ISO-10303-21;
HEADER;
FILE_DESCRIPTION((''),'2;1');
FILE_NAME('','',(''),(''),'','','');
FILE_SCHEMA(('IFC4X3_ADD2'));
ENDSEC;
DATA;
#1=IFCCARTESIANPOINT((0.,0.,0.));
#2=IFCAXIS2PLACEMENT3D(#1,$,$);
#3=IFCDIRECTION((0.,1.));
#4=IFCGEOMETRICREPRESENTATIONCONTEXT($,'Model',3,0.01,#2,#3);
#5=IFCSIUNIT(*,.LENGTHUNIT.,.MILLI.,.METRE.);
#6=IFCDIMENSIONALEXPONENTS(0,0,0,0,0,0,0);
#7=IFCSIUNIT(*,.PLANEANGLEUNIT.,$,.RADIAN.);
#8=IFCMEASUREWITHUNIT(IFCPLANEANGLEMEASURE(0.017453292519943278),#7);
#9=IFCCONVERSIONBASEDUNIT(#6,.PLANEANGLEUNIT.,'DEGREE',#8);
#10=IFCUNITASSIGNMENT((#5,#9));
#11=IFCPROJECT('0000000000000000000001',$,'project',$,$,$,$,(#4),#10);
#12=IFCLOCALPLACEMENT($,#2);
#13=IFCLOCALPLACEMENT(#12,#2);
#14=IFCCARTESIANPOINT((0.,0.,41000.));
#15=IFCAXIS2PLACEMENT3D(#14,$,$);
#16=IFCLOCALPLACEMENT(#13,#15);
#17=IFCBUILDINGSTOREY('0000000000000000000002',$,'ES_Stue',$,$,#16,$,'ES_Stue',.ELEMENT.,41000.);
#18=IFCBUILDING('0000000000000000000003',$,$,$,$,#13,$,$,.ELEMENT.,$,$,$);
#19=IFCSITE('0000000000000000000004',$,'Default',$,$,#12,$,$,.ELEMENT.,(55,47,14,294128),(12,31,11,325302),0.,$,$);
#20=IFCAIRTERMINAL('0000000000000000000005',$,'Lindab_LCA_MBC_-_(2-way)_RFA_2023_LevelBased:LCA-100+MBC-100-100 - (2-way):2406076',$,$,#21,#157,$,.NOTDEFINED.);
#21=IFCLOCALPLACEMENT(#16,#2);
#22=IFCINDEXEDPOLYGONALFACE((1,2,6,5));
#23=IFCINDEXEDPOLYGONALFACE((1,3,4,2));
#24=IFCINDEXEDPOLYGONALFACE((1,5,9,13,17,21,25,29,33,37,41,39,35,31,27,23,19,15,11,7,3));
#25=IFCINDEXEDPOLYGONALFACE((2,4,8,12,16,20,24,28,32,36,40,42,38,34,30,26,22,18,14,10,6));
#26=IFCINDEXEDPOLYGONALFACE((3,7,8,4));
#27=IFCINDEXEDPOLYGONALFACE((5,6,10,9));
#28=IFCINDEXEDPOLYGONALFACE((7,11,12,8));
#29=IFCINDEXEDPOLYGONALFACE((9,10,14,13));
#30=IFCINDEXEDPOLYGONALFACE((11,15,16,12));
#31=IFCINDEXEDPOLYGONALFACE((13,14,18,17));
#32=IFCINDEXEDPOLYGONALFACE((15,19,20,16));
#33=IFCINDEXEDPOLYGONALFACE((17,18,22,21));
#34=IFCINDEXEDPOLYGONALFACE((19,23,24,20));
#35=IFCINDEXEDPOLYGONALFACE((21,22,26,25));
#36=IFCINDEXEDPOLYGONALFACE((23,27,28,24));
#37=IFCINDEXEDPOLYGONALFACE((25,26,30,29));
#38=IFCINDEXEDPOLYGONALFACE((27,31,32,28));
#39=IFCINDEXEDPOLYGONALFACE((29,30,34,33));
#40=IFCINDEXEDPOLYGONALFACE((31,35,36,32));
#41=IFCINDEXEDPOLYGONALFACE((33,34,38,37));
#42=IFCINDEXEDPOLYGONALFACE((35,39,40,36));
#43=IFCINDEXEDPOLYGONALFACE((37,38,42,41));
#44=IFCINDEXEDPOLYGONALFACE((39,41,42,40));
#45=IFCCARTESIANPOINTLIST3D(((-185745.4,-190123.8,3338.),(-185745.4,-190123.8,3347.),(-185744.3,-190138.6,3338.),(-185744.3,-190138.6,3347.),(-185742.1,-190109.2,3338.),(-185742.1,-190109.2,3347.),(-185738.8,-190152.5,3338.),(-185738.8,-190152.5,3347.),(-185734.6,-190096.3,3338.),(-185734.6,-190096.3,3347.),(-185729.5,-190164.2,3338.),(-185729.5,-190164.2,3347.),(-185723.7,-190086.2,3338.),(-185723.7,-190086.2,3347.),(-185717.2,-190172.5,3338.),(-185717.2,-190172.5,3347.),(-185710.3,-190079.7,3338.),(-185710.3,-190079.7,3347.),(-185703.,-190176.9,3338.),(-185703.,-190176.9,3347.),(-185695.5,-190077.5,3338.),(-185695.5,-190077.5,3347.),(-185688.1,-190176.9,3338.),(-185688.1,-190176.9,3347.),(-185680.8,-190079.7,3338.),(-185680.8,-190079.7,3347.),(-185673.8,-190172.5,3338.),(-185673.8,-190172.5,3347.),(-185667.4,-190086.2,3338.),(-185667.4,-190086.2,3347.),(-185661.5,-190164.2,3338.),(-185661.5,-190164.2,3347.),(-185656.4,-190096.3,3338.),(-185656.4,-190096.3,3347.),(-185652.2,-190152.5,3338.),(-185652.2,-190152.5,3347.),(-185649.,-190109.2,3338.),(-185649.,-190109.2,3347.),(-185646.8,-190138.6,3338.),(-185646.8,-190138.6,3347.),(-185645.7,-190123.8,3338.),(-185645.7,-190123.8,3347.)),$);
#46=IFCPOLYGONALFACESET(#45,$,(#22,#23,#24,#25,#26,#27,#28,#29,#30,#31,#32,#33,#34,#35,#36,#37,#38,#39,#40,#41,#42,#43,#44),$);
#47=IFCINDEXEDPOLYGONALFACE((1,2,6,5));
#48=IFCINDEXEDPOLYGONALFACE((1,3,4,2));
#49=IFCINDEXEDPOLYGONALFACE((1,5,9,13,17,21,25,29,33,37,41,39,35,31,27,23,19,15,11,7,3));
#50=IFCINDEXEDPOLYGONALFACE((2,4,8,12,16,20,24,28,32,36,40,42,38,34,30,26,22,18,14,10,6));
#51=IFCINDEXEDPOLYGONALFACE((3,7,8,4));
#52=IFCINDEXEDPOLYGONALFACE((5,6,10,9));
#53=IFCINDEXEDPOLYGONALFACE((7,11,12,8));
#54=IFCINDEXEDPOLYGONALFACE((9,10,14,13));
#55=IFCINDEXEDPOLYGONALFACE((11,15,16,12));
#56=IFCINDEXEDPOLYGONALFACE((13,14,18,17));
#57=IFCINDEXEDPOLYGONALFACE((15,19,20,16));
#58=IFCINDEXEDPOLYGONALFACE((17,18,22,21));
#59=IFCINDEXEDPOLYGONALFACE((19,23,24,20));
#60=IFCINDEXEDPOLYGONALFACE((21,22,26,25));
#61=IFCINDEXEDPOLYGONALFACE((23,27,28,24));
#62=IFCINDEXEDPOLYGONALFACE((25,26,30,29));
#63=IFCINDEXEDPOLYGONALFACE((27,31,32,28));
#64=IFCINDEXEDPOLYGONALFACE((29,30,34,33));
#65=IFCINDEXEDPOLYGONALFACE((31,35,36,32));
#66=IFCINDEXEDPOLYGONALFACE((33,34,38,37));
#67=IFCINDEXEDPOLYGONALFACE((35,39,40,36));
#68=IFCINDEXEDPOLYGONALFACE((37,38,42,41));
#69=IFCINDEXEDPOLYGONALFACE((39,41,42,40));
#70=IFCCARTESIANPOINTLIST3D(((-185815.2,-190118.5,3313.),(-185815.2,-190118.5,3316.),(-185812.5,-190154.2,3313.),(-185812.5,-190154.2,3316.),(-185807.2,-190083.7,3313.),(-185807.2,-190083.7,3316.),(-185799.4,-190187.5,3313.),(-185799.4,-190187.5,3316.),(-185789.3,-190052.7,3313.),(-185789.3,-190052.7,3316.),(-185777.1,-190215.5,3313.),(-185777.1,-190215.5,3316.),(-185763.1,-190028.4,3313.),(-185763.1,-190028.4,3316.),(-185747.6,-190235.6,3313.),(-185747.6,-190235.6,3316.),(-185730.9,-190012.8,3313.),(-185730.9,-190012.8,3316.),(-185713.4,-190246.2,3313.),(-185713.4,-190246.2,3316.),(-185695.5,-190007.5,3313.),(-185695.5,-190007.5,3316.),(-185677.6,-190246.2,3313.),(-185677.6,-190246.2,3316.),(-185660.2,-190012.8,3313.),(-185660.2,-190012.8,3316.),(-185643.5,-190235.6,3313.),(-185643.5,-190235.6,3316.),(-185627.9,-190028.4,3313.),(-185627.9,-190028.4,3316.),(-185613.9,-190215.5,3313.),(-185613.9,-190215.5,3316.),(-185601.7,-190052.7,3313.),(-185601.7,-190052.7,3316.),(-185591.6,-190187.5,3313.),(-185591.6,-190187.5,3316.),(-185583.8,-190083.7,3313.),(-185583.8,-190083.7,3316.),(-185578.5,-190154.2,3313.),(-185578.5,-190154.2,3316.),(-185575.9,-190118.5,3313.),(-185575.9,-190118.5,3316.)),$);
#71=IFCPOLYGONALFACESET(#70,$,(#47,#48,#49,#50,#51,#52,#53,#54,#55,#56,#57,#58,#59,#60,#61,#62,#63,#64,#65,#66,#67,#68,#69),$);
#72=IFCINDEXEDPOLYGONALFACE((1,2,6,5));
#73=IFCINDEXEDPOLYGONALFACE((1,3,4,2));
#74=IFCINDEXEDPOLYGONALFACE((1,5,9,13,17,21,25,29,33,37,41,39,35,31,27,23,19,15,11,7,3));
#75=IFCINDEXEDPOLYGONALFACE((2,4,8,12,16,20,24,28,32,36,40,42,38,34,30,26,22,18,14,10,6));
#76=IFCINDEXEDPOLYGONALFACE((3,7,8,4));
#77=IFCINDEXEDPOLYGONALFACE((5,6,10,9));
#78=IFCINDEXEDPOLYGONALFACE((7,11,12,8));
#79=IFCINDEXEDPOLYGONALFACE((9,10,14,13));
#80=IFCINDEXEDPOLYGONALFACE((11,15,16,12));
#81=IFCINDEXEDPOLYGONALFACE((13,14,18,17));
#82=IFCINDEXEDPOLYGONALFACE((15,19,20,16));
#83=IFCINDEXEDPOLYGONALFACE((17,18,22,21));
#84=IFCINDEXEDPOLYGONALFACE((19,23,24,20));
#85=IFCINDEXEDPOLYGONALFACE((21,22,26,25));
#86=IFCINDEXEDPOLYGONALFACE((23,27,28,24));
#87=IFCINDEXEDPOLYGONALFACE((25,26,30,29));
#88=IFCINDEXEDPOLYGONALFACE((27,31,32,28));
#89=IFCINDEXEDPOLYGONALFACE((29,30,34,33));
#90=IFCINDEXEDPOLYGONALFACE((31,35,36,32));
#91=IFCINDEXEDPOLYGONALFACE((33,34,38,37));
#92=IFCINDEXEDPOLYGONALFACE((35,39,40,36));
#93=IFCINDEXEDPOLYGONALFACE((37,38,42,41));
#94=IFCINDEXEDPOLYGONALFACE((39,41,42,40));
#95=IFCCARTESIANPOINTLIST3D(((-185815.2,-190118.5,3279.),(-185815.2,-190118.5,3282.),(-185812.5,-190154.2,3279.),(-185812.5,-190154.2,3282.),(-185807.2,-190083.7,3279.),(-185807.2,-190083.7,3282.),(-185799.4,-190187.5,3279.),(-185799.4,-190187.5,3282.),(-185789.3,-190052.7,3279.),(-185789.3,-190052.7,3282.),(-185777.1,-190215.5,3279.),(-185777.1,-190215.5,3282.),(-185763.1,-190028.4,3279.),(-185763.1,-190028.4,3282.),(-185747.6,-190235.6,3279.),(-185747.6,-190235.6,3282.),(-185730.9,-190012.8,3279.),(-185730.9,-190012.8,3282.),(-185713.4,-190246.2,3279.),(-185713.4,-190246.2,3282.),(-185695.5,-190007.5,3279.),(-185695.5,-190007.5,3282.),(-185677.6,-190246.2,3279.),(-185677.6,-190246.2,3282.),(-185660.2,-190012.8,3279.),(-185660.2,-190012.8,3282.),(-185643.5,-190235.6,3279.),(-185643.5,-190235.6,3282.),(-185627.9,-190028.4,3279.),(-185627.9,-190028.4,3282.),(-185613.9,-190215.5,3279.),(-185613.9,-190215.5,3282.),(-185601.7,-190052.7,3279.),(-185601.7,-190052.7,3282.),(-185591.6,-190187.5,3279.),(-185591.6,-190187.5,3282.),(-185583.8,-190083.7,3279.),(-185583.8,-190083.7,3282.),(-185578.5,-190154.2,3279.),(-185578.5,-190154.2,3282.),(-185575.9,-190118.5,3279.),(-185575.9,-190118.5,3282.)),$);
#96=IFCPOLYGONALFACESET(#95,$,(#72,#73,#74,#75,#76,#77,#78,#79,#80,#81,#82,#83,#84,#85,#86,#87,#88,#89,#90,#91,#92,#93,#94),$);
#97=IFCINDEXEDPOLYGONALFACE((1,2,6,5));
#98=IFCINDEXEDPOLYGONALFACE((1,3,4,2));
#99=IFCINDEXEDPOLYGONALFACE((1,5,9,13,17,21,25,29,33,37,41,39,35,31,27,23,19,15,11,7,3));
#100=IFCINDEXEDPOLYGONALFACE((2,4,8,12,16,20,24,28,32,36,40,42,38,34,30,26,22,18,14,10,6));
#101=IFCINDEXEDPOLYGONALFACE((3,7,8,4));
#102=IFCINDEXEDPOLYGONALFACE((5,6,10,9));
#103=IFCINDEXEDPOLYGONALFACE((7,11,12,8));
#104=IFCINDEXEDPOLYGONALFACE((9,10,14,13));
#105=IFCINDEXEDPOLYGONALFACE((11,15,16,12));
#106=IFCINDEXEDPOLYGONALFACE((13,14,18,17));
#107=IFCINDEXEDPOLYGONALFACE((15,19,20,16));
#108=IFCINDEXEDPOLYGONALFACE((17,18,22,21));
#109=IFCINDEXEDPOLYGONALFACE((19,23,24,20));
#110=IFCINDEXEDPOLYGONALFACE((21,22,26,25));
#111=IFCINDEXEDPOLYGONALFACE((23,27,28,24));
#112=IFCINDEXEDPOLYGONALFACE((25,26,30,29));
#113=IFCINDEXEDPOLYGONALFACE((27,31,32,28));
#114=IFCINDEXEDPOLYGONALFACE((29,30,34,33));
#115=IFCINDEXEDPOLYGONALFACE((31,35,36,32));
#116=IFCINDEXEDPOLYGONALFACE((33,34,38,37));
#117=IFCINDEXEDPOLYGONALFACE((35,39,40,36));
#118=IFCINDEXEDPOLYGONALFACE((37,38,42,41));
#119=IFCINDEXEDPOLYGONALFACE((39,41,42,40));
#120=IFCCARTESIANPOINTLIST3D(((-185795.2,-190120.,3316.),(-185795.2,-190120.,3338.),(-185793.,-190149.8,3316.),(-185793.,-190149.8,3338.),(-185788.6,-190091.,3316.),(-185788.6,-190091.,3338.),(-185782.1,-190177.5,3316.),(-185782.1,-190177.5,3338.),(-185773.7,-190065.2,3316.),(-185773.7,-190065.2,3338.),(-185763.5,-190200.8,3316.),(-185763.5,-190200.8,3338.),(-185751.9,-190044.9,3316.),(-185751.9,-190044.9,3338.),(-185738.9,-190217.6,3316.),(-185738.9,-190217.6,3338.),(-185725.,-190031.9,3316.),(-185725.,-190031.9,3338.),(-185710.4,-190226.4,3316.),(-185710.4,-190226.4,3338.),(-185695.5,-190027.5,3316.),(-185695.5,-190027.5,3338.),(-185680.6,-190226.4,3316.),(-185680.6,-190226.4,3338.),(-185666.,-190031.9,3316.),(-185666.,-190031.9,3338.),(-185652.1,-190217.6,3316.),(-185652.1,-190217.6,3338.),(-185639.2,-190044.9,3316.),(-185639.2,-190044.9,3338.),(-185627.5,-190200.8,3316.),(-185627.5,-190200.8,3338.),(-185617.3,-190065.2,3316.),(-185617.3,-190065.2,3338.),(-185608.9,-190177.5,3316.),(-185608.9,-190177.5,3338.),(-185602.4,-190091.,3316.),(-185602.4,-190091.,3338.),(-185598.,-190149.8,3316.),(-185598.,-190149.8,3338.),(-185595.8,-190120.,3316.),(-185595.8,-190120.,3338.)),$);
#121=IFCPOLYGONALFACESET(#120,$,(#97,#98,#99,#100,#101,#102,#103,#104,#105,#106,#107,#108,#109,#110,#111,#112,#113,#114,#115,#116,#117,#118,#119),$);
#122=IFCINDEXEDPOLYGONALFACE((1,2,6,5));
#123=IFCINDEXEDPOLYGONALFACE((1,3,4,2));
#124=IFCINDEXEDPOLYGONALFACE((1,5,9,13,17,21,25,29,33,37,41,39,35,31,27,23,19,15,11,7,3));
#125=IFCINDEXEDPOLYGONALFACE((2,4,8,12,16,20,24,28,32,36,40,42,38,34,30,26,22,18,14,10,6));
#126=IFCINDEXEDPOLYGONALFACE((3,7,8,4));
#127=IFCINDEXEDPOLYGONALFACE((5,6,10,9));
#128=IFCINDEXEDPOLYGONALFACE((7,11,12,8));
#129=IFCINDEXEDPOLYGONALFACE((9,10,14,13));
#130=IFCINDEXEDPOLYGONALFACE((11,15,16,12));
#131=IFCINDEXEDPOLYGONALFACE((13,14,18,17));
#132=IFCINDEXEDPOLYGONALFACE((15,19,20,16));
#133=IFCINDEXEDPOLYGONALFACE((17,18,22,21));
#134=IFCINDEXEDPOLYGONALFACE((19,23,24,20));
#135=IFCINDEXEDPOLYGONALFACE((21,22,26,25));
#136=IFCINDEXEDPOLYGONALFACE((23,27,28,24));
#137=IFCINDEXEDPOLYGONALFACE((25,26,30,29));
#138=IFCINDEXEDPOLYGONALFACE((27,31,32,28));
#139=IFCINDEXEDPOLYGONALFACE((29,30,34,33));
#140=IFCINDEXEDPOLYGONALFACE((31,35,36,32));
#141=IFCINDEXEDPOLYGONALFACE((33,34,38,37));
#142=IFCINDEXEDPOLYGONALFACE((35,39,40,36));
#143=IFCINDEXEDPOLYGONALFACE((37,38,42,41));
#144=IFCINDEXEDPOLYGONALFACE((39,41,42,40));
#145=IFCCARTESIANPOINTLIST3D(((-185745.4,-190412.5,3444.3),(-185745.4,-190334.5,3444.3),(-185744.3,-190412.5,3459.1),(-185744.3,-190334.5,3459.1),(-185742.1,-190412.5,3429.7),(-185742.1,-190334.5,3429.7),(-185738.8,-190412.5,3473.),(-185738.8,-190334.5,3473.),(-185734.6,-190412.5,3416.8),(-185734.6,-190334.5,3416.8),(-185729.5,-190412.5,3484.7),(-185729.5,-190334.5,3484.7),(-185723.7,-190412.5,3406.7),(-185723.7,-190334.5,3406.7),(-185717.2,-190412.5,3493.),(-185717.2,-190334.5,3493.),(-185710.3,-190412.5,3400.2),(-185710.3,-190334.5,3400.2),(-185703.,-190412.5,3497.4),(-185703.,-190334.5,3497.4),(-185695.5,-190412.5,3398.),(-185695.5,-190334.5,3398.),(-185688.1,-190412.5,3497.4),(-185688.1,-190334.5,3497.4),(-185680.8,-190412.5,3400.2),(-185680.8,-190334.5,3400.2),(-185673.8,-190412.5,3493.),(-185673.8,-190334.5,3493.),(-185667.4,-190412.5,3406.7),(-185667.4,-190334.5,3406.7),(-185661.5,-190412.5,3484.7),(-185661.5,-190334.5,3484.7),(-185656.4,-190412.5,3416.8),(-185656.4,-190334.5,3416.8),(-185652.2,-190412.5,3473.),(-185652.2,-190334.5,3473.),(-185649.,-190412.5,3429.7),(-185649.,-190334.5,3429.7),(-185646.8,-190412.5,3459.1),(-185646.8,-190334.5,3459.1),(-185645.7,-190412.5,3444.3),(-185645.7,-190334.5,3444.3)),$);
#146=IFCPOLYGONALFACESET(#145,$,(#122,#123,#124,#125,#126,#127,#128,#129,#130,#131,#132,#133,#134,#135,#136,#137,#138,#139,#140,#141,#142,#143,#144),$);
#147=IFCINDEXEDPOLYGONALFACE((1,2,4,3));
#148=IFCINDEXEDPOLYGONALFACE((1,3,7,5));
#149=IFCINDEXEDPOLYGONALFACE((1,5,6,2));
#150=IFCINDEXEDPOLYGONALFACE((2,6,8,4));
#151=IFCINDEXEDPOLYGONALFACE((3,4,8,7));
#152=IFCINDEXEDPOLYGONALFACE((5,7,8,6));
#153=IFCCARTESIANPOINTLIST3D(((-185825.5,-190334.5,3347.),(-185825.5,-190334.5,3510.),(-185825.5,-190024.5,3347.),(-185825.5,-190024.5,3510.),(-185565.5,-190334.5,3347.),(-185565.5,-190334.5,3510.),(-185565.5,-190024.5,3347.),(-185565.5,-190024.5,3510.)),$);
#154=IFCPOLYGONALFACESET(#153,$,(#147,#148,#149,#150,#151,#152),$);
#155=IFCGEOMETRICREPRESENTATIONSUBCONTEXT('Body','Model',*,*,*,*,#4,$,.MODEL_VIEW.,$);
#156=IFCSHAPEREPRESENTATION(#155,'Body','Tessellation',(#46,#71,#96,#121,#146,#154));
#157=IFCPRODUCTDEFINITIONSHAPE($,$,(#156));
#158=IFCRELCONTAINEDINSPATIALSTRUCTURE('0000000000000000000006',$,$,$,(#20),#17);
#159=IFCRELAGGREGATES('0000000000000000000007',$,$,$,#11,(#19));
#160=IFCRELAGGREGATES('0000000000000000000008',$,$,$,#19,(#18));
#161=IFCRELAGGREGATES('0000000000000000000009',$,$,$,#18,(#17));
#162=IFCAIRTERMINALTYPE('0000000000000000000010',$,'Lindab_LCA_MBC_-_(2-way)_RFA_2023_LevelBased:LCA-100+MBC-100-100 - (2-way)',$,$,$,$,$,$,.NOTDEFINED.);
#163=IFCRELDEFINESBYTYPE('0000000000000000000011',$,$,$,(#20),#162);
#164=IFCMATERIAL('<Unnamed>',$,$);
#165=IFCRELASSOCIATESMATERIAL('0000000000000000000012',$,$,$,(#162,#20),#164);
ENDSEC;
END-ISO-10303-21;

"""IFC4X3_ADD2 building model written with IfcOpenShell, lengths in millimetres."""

from ifc_helpers import new_model, entity, si_unit, converted_unit, direction, frame, frame_2d, origin, origin_2d_with_axis, place, context, subcontext, project, spatial, rectangle, circle, extrude, source, transform, mapped, material, type_object, type_shapes, element, save


model = new_model("IFC4X3_ADD2")

# Units and contexts
model_context = context("Model", 3, precision=0.01, world=origin(), true_north=direction((0.0, 1.0)))
body_context = subcontext(model_context, "Body", "Model", "MODEL_VIEW")
ifc_project = project(units=[si_unit("LENGTHUNIT", "METRE", prefix="MILLI"), converted_unit("PLANEANGLEUNIT", "DEGREE", entity("IfcPlaneAngleMeasure", 0.017453292519943278), si_unit("PLANEANGLEUNIT", "RADIAN"), dimensions=[0, 0, 0, 0, 0, 0, 0])], contexts=[model_context])

# Site, building, storey
site_placement = place(None, origin())
site = spatial("IfcSite", under=ifc_project, at=site_placement, Name="Default", CompositionType="ELEMENT", RefLatitude=(55, 47, 14, 294128), RefLongitude=(12, 31, 11, 325302), RefElevation=0.0)
building_placement = place(site_placement, origin())
building = spatial("IfcBuilding", under=site, at=building_placement, CompositionType="ELEMENT")
storey_placement = place(building_placement, frame((0.0, 0.0, 41000.0)))
storey = spatial("IfcBuildingStorey", under=building, at=storey_placement, Name="ES_Stue", LongName="ES_Stue", CompositionType="ELEMENT", Elevation=41000.0)

# Air terminal
ifc_material_1 = material(Name="<Unnamed>")
air_terminal_type = type_object("IfcAirTerminalType", Name="Lindab_LCA_MBC_-_(2-way)_RFA_2023_LevelBased:LCA-100+MBC-100-100 - (2-way)", PredefinedType="NOTDEFINED", material=ifc_material_1)
shared_shape_1 = source(origin(), body_context, "Body", "SweptSolid", [
    extrude(circle(Radius=50.0, at=frame_2d((0.0, 0.0), x_axis=(1.0, 0.0))), frame((0.0, 0.0, 22.0)), (0.0, 0.0, 1.0), 9.0),
    extrude(circle(Radius=120.0, at=frame_2d((0.0, 0.0), x_axis=(1.0, 0.0))), frame((0.0, 0.0, -3.0)), (0.0, 0.0, 1.0), 3.0),
    extrude(circle(Radius=120.0, at=frame_2d((0.0, 0.0), x_axis=(1.0, 0.0))), frame((0.0, 0.0, -37.0)), (0.0, 0.0, 1.0), 3.0),
    extrude(circle(Radius=100.0, at=frame_2d((0.0, 0.0), x_axis=(1.0, 0.0))), origin(), (0.0, 0.0, 1.0), 22.0),
    extrude(circle(Radius=50.0, at=frame_2d((0.0, 0.0), x_axis=(1.0, 0.0))), frame((-285.0, 0.0, 132.0), z_axis=(1.0, 0.0, 0.0), x_axis=(0.0, 0.0, -1.0)), (0.0, 0.0, 1.0), 78.0),
    extrude(rectangle(XDim=260.0, YDim=310.0, at=origin_2d_with_axis()), frame((-52.0, 0.0, 31.0), z_axis=(0.0, 0.0, 1.0), x_axis=(0.0, -1.0, 0.0)), (0.0, 0.0, 1.0), 163.0),
])
type_shapes(air_terminal_type, [shared_shape_1])
for number, where, z_axis, x_axis, name in (
    (1, (-185695.5, -190127.5, 3316.0), (0.0, 0.0, 1.0), (0.0, 1.0, 0.0), "Lindab_LCA_MBC_-_(2-way)_RFA_2023_LevelBased:LCA-100+MBC-100-100 - (2-way):2406076"),
):
    element("IfcAirTerminal", number, at=place(storey_placement, frame(where, z_axis=z_axis, x_axis=x_axis)), inside=storey, type_object=air_terminal_type, material=ifc_material_1, Name=name, PredefinedType="NOTDEFINED", context=body_context, shape_type="MappedRepresentation", body=[
        mapped(shared_shape_1, transform((0.0, 0.0, 0.0), scale=1.0)),
    ])

save(model, "model.ifc")
